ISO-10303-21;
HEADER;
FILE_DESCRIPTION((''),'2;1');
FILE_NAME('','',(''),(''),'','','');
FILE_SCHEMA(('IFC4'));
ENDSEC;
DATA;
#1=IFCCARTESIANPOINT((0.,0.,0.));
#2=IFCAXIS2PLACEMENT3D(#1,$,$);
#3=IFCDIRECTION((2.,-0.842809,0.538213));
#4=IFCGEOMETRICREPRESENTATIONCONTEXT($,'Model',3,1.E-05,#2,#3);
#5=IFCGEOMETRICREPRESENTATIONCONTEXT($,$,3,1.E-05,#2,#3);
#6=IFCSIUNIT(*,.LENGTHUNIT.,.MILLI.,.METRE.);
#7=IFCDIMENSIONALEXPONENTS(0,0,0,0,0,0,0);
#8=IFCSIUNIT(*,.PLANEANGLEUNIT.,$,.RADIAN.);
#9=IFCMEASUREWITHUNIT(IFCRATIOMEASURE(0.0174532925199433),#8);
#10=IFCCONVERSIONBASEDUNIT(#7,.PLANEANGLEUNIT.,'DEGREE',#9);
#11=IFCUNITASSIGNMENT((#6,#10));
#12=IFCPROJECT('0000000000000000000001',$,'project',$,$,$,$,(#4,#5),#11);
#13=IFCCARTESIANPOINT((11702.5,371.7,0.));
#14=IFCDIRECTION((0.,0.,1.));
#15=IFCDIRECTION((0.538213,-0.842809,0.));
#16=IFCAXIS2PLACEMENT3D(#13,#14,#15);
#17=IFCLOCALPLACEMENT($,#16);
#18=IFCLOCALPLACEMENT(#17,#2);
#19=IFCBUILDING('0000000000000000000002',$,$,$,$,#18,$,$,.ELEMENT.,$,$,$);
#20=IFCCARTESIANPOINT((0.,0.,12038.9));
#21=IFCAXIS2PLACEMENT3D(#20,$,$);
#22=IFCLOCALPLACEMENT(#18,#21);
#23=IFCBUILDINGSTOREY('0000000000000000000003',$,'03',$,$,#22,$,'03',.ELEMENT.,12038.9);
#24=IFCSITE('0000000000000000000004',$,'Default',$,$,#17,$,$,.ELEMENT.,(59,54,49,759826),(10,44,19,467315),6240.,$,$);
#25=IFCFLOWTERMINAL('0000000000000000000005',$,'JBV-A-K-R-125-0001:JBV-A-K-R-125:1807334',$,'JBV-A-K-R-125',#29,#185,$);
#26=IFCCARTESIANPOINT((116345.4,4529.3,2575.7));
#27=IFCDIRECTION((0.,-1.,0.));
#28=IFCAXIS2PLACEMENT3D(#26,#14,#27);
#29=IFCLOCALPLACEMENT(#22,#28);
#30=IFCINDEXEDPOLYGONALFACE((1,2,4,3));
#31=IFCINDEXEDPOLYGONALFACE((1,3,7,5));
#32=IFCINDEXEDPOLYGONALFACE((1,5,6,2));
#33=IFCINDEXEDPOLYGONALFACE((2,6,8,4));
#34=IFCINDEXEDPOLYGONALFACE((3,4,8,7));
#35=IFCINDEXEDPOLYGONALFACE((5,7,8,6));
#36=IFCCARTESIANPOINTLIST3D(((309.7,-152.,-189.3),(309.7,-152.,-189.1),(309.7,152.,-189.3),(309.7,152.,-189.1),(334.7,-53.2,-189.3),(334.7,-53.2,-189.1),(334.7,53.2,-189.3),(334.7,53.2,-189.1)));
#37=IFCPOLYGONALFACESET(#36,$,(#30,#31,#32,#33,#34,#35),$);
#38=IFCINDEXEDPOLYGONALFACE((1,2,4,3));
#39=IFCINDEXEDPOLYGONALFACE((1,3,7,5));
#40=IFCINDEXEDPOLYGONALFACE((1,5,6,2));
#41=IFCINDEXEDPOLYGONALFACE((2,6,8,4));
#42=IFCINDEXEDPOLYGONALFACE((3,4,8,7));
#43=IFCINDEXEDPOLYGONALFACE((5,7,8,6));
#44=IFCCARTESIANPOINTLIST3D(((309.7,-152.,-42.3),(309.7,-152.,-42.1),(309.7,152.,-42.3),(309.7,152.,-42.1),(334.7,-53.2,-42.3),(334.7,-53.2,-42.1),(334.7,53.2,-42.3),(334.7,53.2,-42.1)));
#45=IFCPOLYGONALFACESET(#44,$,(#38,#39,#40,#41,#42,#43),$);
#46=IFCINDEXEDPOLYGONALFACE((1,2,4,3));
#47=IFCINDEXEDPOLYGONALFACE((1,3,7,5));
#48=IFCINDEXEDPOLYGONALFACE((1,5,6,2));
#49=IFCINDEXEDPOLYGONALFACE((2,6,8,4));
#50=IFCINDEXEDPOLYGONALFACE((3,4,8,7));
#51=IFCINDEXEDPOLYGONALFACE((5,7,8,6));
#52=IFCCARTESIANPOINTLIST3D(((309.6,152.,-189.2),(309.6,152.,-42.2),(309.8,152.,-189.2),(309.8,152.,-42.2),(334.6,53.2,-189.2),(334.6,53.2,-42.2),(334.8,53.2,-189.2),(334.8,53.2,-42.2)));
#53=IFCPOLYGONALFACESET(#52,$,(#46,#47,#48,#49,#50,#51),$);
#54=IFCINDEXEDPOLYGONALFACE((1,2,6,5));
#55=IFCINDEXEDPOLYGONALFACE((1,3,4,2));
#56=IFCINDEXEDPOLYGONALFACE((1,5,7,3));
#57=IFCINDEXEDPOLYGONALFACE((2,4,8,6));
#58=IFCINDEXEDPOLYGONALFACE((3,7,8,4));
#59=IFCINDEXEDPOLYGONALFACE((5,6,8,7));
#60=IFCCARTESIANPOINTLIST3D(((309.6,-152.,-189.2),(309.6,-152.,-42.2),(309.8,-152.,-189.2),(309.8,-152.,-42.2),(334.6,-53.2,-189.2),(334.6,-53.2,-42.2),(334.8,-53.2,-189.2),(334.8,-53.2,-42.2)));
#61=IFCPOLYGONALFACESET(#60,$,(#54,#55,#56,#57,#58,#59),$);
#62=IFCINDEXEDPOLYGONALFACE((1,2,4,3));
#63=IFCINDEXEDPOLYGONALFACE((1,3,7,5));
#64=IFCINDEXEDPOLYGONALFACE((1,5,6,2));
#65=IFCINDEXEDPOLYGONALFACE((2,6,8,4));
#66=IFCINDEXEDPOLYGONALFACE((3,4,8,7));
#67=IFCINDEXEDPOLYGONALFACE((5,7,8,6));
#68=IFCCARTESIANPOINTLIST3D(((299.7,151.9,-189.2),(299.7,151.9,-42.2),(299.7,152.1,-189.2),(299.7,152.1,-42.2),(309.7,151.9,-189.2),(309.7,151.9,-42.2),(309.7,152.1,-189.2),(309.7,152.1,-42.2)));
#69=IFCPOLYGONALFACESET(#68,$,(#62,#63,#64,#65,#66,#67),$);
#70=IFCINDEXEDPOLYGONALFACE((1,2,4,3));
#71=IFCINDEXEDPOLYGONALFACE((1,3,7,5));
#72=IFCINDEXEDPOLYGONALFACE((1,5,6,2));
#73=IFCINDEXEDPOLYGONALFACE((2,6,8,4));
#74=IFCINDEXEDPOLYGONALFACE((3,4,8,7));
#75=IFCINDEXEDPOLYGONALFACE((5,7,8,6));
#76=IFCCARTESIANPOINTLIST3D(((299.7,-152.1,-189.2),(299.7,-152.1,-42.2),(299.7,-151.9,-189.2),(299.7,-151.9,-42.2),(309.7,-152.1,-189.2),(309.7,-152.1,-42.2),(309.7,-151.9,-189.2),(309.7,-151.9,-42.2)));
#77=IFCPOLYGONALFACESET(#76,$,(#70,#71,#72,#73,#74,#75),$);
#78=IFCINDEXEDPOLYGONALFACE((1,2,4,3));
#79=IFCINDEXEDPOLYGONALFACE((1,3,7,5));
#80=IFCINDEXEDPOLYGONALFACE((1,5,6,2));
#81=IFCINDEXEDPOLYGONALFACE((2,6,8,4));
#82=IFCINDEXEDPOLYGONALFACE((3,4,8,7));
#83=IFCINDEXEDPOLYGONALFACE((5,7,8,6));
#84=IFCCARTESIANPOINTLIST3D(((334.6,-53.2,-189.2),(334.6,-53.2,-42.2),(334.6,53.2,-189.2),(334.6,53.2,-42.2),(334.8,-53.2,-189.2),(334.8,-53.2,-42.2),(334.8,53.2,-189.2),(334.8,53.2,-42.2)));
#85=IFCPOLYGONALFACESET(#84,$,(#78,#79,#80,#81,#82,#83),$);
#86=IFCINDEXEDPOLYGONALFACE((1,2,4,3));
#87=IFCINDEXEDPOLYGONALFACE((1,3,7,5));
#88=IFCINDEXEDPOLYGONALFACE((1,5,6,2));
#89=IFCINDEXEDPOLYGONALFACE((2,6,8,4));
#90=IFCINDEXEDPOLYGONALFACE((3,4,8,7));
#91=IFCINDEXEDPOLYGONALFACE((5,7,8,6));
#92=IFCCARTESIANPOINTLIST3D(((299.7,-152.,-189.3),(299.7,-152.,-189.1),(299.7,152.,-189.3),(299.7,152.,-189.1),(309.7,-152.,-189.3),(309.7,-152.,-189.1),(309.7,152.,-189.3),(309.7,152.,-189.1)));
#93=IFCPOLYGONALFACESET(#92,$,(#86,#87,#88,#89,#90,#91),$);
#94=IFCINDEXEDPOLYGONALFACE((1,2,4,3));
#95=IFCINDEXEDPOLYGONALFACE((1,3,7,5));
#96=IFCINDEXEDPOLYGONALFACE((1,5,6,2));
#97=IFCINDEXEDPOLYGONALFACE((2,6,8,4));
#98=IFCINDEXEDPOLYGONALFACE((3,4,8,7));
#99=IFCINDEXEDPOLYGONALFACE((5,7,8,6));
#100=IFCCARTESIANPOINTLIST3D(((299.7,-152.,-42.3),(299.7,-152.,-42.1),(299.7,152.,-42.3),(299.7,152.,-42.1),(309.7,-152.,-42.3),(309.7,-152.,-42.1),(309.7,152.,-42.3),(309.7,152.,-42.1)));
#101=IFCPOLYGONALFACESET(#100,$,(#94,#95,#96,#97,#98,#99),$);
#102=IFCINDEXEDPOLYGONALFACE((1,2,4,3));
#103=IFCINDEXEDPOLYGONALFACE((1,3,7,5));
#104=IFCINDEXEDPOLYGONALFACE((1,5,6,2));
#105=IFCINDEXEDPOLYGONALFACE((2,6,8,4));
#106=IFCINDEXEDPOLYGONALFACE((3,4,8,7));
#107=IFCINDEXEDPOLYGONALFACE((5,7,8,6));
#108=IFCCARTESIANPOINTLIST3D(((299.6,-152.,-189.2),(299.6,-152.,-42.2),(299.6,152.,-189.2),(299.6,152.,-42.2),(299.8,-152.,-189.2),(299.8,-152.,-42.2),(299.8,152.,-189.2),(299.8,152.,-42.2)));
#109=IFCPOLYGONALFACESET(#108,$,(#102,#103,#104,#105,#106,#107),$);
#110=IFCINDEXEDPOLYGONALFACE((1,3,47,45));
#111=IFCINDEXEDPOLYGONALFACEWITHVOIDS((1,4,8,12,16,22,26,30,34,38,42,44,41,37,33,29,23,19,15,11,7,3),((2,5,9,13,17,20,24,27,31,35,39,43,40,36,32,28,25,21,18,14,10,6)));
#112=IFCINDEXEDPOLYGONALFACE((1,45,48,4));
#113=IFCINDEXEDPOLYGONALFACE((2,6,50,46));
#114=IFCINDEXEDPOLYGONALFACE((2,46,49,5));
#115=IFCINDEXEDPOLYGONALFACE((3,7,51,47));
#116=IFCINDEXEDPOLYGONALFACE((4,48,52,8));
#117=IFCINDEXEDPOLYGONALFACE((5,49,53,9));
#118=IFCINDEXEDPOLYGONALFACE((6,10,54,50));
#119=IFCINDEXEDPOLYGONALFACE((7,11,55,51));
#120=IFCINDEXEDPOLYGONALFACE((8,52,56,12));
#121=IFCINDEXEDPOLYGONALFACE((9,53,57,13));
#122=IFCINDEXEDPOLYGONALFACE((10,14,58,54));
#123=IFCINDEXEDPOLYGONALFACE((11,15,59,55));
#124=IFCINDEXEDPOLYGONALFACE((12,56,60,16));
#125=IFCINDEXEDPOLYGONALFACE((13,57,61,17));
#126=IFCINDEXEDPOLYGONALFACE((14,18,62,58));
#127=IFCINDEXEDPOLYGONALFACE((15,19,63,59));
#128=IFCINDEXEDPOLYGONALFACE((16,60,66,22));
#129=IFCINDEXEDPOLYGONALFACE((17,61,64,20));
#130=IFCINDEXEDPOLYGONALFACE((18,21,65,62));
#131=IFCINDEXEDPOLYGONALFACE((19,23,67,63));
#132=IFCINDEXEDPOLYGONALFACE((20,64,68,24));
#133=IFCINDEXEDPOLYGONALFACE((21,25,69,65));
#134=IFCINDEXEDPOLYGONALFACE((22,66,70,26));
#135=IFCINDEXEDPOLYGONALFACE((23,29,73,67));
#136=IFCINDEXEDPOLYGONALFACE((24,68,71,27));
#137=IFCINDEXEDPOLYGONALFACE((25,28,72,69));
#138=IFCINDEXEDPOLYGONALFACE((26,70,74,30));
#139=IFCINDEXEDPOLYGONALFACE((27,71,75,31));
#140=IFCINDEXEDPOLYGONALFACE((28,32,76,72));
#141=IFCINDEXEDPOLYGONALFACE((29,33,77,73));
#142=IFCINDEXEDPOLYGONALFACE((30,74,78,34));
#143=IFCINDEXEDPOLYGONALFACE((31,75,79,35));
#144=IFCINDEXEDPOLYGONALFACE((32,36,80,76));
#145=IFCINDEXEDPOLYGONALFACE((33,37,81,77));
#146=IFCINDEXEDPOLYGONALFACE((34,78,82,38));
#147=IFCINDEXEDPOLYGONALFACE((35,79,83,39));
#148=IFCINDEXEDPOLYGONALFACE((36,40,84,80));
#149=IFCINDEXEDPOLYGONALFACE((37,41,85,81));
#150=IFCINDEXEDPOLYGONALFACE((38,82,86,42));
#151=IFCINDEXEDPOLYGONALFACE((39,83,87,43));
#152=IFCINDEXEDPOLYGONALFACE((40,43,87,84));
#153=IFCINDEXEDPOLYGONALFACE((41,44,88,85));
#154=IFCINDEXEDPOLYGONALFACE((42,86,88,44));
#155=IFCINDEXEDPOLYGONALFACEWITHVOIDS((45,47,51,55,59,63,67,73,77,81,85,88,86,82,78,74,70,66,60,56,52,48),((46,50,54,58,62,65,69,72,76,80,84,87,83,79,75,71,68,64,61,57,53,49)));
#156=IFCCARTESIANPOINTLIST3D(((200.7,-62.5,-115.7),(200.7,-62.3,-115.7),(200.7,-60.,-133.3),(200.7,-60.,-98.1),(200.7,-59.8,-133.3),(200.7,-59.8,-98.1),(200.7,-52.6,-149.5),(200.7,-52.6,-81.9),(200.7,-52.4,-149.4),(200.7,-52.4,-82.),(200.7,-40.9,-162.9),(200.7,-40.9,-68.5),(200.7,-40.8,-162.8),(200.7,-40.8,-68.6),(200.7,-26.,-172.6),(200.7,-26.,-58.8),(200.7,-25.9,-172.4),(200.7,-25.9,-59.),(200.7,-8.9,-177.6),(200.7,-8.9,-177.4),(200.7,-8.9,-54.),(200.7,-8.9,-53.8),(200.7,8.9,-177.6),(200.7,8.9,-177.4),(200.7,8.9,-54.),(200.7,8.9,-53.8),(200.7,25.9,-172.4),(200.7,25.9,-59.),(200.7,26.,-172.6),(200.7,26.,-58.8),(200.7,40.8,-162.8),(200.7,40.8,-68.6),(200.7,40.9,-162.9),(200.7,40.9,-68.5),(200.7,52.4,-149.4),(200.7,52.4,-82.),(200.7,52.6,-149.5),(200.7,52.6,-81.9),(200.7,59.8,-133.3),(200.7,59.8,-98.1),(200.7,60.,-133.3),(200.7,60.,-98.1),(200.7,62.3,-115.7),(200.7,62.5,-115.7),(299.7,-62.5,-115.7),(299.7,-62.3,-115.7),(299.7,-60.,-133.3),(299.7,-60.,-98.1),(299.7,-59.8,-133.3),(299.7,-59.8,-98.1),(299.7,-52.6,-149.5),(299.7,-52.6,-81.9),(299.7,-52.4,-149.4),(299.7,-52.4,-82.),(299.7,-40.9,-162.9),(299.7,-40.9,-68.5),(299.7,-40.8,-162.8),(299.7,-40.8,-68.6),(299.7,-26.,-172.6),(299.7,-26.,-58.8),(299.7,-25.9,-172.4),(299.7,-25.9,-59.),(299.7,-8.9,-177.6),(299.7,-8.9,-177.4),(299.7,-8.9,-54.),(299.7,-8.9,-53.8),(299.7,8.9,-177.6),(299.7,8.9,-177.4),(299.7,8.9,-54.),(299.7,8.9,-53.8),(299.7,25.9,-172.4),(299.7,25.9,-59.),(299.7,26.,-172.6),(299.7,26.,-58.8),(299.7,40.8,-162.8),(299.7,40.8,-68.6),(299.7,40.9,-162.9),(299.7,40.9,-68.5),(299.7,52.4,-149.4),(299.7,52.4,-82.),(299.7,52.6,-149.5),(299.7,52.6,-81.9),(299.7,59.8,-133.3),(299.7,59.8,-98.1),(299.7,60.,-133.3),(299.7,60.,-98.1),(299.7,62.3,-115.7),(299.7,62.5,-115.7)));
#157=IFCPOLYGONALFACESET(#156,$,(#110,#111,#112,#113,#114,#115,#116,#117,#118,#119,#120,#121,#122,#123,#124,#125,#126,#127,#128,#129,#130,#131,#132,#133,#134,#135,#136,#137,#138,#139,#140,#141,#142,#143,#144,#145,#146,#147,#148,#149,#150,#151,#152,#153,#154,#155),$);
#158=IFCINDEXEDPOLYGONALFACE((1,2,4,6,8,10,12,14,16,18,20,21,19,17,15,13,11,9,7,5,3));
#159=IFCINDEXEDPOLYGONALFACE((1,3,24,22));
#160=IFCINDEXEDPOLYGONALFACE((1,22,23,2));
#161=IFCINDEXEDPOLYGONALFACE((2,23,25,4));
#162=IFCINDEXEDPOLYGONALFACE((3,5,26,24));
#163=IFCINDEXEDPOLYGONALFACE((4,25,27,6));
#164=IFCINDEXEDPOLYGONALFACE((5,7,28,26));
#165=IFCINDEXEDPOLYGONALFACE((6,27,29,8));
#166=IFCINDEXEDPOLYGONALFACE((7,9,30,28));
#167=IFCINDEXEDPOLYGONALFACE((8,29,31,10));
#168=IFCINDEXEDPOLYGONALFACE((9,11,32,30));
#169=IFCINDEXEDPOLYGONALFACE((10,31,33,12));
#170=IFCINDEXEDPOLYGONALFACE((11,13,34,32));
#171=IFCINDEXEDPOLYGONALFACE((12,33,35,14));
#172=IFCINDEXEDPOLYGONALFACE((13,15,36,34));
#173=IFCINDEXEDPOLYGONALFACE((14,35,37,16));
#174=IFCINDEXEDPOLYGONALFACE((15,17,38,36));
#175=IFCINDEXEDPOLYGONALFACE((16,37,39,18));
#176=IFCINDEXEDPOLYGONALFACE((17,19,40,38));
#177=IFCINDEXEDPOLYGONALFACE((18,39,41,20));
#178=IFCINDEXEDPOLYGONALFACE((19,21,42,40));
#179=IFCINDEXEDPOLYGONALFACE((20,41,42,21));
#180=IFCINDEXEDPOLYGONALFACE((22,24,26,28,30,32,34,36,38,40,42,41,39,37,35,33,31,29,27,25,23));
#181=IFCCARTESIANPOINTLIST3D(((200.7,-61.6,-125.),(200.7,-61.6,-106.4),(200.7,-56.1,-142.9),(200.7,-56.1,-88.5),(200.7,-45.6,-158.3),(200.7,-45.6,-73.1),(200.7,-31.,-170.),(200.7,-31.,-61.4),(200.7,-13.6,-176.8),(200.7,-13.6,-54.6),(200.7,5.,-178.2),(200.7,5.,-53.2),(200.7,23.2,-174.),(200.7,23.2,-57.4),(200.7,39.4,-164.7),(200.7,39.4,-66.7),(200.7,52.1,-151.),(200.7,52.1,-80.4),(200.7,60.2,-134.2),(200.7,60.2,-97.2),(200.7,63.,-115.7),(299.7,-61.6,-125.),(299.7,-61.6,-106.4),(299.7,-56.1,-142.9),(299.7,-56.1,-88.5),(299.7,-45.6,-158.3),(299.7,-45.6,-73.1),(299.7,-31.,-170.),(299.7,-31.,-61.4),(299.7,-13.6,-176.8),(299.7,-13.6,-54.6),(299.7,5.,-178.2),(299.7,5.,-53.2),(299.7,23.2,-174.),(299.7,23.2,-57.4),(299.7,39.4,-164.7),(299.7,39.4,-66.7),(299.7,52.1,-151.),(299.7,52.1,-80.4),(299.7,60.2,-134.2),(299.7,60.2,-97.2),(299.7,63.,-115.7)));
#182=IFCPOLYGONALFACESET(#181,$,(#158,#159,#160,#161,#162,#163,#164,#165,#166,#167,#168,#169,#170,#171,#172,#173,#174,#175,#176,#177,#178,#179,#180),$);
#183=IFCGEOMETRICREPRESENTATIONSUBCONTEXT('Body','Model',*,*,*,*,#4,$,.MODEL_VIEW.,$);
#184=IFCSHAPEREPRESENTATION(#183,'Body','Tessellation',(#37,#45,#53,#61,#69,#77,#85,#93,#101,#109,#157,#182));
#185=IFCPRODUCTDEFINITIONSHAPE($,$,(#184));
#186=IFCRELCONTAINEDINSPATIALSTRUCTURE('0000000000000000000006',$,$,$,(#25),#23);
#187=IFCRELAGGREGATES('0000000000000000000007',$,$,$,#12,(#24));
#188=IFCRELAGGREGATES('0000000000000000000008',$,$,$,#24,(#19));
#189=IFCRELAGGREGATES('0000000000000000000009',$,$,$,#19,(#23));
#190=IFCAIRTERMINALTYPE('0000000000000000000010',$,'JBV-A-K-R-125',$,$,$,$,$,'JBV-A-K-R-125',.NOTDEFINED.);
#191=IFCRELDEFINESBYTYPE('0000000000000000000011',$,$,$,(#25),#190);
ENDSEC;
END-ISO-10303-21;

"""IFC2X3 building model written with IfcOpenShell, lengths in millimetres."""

from ifc_helpers import new_model, entity, si_unit, converted_unit, direction, frame, frame_2d, origin, origin_2d_with_axis, place, context, subcontext, project, spatial, polyline, circle_curve, parameter, trimmed, segment, composite_curve, rectangle, circle, outline, extrude, source, transform, mapped, type_object, type_shapes, element, save


model = new_model("IFC2X3")

# Units and contexts
model_context = context("Model", 3, precision=1e-05, world=origin(), true_north=direction((2.0, -0.842809, 0.538213)))
context_of_model = context(None, 3, precision=1e-05, world=origin(), true_north=direction((2.0, -0.842809, 0.538213)))
body_context = subcontext(model_context, "Body", "Model", "MODEL_VIEW")
ifc_project = project(units=[si_unit("LENGTHUNIT", "METRE", prefix="MILLI"), converted_unit("PLANEANGLEUNIT", "DEGREE", entity("IfcRatioMeasure", 0.0174532925199433), si_unit("PLANEANGLEUNIT", "RADIAN"), dimensions=[0, 0, 0, 0, 0, 0, 0])], contexts=[model_context, context_of_model])

# Site, building, storey
site_placement = place(None, frame((11702.5, 371.7, 0.0), z_axis=(0.0, 0.0, 1.0), x_axis=(0.538213, -0.842809, 0.0)))
site = spatial("IfcSite", under=ifc_project, at=site_placement, Name="Default", CompositionType="ELEMENT", RefLatitude=(59, 54, 49, 759826), RefLongitude=(10, 44, 19, 467315), RefElevation=6240.0)
building_placement = place(site_placement, origin())
building = spatial("IfcBuilding", under=site, at=building_placement, CompositionType="ELEMENT")
storey_placement = place(building_placement, frame((0.0, 0.0, 12038.9)))
storey = spatial("IfcBuildingStorey", under=building, at=storey_placement, Name="03", LongName="03", CompositionType="ELEMENT", Elevation=12038.9)

# Flow terminal
air_terminal_type_1 = type_object("IfcAirTerminalType", Name="JBV-A-K-R-125", ElementType="JBV-A-K-R-125", PredefinedType="NOTDEFINED")
shared_shape_1 = source(origin(), body_context, "Body", "SweptSolid", [
    extrude(outline(polyline([(-152.0, -12.5), (152.0, -12.5), (53.2, 12.5), (-53.2, 12.5), (-152.0, -12.5)])), frame((322.2, 0.0, -189.3), z_axis=(0.0, 0.0, 1.0), x_axis=(0.0, -1.0, 0.0)), (0.0, 0.0, 1.0), 0.2),
    extrude(outline(polyline([(-152.0, -12.5), (152.0, -12.5), (53.2, 12.5), (-53.2, 12.5), (-152.0, -12.5)])), frame((322.2, 0.0, -42.3), z_axis=(0.0, 0.0, 1.0), x_axis=(0.0, -1.0, 0.0)), (0.0, 0.0, 1.0), 0.2),
    extrude(rectangle(XDim=0.2, YDim=101.9, at=frame_2d((0.0, 0.0), x_axis=(1.0, 0.0))), frame((322.2, 102.6, -189.2), z_axis=(0.0, 0.0, 1.0), x_axis=(0.969446, 0.245305, 0.0)), (0.0, 0.0, 1.0), 147.0),
    extrude(rectangle(XDim=0.2, YDim=101.9, at=frame_2d((0.0, 0.0), x_axis=(1.0, 0.0))), frame((322.2, -102.6, -189.2), z_axis=(0.0, 0.0, 1.0), x_axis=(-0.969446, 0.245305, 0.0)), (0.0, 0.0, 1.0), 147.0),
    extrude(rectangle(XDim=0.2, YDim=10.0, at=frame_2d((0.0, 0.0), x_axis=(1.0, 0.0))), frame((304.7, 152.0, -189.2), z_axis=(0.0, 0.0, 1.0), x_axis=(0.0, 1.0, 0.0)), (0.0, 0.0, 1.0), 147.0),
    extrude(rectangle(XDim=0.2, YDim=10.0, at=frame_2d((0.0, 0.0), x_axis=(1.0, 0.0))), frame((304.7, -152.0, -189.2), z_axis=(0.0, 0.0, 1.0), x_axis=(0.0, 1.0, 0.0)), (0.0, 0.0, 1.0), 147.0),
    extrude(rectangle(XDim=0.2, YDim=106.4, at=frame_2d((0.0, 0.0), x_axis=(1.0, 0.0))), frame((334.7, 0.0, -189.2)), (0.0, 0.0, 1.0), 147.0),
    extrude(rectangle(XDim=304.0, YDim=10.0, at=frame_2d((0.0, 0.0), x_axis=(1.0, 0.0))), frame((304.7, 0.0, -189.3), z_axis=(0.0, 0.0, 1.0), x_axis=(0.0, -1.0, 0.0)), (0.0, 0.0, 1.0), 0.2),
    extrude(rectangle(XDim=304.0, YDim=10.0, at=frame_2d((0.0, 0.0), x_axis=(1.0, 0.0))), frame((304.7, 0.0, -42.3), z_axis=(0.0, 0.0, 1.0), x_axis=(0.0, -1.0, 0.0)), (0.0, 0.0, 1.0), 0.2),
    extrude(rectangle(XDim=0.2, YDim=304.0, at=frame_2d((0.0, 0.0), x_axis=(1.0, 0.0))), frame((299.7, 0.0, -189.2)), (0.0, 0.0, 1.0), 147.0),
    extrude(outline(composite_curve([segment(trimmed(circle_curve(origin_2d_with_axis(), 62.5), [parameter(0.0)], [parameter(180.0)], True, "PARAMETER"), True, "CONTINUOUS"), segment(trimmed(circle_curve(origin_2d_with_axis(), 62.5), [parameter(180.0)], [parameter(360.0)], True, "PARAMETER"), True, "CONTINUOUS")], self_intersect=False), holes=[composite_curve([segment(trimmed(circle_curve(origin_2d_with_axis(), 62.3), [parameter(180.0)], [parameter(360.0)], True, "PARAMETER"), False, "CONTINUOUS"), segment(trimmed(circle_curve(origin_2d_with_axis(), 62.3), [parameter(0.0)], [parameter(180.0)], True, "PARAMETER"), False, "CONTINUOUS")], self_intersect=False)]), frame((200.7, 0.0, -115.7), z_axis=(1.0, 0.0, 0.0), x_axis=(0.0, 1.0, 0.0)), (0.0, 0.0, 1.0), 99.0),
    extrude(circle(Radius=62.6, at=frame_2d((0.0, 0.0), x_axis=(1.0, 0.0))), frame((200.7, 0.3, -115.7), z_axis=(1.0, 0.0, 0.0), x_axis=(0.0, 1.0, 0.0)), (0.0, 0.0, 1.0), 99.0),
])
type_shapes(air_terminal_type_1, [shared_shape_1])
for number, where, z_axis, x_axis, name in (
    (1, (116345.4, 4529.3, 2575.7), (0.0, 0.0, 1.0), (0.0, -1.0, 0.0), "JBV-A-K-R-125-0001:JBV-A-K-R-125:1807334"),
):
    element("IfcFlowTerminal", number, at=place(storey_placement, frame(where, z_axis=z_axis, x_axis=x_axis)), inside=storey, type_object=air_terminal_type_1, Name=name, ObjectType="JBV-A-K-R-125", context=body_context, shape_type="MappedRepresentation", body=[
        mapped(shared_shape_1, transform((0.0, 0.0, 0.0), scale=1.0)),
    ])

save(model, "model.ifc")
